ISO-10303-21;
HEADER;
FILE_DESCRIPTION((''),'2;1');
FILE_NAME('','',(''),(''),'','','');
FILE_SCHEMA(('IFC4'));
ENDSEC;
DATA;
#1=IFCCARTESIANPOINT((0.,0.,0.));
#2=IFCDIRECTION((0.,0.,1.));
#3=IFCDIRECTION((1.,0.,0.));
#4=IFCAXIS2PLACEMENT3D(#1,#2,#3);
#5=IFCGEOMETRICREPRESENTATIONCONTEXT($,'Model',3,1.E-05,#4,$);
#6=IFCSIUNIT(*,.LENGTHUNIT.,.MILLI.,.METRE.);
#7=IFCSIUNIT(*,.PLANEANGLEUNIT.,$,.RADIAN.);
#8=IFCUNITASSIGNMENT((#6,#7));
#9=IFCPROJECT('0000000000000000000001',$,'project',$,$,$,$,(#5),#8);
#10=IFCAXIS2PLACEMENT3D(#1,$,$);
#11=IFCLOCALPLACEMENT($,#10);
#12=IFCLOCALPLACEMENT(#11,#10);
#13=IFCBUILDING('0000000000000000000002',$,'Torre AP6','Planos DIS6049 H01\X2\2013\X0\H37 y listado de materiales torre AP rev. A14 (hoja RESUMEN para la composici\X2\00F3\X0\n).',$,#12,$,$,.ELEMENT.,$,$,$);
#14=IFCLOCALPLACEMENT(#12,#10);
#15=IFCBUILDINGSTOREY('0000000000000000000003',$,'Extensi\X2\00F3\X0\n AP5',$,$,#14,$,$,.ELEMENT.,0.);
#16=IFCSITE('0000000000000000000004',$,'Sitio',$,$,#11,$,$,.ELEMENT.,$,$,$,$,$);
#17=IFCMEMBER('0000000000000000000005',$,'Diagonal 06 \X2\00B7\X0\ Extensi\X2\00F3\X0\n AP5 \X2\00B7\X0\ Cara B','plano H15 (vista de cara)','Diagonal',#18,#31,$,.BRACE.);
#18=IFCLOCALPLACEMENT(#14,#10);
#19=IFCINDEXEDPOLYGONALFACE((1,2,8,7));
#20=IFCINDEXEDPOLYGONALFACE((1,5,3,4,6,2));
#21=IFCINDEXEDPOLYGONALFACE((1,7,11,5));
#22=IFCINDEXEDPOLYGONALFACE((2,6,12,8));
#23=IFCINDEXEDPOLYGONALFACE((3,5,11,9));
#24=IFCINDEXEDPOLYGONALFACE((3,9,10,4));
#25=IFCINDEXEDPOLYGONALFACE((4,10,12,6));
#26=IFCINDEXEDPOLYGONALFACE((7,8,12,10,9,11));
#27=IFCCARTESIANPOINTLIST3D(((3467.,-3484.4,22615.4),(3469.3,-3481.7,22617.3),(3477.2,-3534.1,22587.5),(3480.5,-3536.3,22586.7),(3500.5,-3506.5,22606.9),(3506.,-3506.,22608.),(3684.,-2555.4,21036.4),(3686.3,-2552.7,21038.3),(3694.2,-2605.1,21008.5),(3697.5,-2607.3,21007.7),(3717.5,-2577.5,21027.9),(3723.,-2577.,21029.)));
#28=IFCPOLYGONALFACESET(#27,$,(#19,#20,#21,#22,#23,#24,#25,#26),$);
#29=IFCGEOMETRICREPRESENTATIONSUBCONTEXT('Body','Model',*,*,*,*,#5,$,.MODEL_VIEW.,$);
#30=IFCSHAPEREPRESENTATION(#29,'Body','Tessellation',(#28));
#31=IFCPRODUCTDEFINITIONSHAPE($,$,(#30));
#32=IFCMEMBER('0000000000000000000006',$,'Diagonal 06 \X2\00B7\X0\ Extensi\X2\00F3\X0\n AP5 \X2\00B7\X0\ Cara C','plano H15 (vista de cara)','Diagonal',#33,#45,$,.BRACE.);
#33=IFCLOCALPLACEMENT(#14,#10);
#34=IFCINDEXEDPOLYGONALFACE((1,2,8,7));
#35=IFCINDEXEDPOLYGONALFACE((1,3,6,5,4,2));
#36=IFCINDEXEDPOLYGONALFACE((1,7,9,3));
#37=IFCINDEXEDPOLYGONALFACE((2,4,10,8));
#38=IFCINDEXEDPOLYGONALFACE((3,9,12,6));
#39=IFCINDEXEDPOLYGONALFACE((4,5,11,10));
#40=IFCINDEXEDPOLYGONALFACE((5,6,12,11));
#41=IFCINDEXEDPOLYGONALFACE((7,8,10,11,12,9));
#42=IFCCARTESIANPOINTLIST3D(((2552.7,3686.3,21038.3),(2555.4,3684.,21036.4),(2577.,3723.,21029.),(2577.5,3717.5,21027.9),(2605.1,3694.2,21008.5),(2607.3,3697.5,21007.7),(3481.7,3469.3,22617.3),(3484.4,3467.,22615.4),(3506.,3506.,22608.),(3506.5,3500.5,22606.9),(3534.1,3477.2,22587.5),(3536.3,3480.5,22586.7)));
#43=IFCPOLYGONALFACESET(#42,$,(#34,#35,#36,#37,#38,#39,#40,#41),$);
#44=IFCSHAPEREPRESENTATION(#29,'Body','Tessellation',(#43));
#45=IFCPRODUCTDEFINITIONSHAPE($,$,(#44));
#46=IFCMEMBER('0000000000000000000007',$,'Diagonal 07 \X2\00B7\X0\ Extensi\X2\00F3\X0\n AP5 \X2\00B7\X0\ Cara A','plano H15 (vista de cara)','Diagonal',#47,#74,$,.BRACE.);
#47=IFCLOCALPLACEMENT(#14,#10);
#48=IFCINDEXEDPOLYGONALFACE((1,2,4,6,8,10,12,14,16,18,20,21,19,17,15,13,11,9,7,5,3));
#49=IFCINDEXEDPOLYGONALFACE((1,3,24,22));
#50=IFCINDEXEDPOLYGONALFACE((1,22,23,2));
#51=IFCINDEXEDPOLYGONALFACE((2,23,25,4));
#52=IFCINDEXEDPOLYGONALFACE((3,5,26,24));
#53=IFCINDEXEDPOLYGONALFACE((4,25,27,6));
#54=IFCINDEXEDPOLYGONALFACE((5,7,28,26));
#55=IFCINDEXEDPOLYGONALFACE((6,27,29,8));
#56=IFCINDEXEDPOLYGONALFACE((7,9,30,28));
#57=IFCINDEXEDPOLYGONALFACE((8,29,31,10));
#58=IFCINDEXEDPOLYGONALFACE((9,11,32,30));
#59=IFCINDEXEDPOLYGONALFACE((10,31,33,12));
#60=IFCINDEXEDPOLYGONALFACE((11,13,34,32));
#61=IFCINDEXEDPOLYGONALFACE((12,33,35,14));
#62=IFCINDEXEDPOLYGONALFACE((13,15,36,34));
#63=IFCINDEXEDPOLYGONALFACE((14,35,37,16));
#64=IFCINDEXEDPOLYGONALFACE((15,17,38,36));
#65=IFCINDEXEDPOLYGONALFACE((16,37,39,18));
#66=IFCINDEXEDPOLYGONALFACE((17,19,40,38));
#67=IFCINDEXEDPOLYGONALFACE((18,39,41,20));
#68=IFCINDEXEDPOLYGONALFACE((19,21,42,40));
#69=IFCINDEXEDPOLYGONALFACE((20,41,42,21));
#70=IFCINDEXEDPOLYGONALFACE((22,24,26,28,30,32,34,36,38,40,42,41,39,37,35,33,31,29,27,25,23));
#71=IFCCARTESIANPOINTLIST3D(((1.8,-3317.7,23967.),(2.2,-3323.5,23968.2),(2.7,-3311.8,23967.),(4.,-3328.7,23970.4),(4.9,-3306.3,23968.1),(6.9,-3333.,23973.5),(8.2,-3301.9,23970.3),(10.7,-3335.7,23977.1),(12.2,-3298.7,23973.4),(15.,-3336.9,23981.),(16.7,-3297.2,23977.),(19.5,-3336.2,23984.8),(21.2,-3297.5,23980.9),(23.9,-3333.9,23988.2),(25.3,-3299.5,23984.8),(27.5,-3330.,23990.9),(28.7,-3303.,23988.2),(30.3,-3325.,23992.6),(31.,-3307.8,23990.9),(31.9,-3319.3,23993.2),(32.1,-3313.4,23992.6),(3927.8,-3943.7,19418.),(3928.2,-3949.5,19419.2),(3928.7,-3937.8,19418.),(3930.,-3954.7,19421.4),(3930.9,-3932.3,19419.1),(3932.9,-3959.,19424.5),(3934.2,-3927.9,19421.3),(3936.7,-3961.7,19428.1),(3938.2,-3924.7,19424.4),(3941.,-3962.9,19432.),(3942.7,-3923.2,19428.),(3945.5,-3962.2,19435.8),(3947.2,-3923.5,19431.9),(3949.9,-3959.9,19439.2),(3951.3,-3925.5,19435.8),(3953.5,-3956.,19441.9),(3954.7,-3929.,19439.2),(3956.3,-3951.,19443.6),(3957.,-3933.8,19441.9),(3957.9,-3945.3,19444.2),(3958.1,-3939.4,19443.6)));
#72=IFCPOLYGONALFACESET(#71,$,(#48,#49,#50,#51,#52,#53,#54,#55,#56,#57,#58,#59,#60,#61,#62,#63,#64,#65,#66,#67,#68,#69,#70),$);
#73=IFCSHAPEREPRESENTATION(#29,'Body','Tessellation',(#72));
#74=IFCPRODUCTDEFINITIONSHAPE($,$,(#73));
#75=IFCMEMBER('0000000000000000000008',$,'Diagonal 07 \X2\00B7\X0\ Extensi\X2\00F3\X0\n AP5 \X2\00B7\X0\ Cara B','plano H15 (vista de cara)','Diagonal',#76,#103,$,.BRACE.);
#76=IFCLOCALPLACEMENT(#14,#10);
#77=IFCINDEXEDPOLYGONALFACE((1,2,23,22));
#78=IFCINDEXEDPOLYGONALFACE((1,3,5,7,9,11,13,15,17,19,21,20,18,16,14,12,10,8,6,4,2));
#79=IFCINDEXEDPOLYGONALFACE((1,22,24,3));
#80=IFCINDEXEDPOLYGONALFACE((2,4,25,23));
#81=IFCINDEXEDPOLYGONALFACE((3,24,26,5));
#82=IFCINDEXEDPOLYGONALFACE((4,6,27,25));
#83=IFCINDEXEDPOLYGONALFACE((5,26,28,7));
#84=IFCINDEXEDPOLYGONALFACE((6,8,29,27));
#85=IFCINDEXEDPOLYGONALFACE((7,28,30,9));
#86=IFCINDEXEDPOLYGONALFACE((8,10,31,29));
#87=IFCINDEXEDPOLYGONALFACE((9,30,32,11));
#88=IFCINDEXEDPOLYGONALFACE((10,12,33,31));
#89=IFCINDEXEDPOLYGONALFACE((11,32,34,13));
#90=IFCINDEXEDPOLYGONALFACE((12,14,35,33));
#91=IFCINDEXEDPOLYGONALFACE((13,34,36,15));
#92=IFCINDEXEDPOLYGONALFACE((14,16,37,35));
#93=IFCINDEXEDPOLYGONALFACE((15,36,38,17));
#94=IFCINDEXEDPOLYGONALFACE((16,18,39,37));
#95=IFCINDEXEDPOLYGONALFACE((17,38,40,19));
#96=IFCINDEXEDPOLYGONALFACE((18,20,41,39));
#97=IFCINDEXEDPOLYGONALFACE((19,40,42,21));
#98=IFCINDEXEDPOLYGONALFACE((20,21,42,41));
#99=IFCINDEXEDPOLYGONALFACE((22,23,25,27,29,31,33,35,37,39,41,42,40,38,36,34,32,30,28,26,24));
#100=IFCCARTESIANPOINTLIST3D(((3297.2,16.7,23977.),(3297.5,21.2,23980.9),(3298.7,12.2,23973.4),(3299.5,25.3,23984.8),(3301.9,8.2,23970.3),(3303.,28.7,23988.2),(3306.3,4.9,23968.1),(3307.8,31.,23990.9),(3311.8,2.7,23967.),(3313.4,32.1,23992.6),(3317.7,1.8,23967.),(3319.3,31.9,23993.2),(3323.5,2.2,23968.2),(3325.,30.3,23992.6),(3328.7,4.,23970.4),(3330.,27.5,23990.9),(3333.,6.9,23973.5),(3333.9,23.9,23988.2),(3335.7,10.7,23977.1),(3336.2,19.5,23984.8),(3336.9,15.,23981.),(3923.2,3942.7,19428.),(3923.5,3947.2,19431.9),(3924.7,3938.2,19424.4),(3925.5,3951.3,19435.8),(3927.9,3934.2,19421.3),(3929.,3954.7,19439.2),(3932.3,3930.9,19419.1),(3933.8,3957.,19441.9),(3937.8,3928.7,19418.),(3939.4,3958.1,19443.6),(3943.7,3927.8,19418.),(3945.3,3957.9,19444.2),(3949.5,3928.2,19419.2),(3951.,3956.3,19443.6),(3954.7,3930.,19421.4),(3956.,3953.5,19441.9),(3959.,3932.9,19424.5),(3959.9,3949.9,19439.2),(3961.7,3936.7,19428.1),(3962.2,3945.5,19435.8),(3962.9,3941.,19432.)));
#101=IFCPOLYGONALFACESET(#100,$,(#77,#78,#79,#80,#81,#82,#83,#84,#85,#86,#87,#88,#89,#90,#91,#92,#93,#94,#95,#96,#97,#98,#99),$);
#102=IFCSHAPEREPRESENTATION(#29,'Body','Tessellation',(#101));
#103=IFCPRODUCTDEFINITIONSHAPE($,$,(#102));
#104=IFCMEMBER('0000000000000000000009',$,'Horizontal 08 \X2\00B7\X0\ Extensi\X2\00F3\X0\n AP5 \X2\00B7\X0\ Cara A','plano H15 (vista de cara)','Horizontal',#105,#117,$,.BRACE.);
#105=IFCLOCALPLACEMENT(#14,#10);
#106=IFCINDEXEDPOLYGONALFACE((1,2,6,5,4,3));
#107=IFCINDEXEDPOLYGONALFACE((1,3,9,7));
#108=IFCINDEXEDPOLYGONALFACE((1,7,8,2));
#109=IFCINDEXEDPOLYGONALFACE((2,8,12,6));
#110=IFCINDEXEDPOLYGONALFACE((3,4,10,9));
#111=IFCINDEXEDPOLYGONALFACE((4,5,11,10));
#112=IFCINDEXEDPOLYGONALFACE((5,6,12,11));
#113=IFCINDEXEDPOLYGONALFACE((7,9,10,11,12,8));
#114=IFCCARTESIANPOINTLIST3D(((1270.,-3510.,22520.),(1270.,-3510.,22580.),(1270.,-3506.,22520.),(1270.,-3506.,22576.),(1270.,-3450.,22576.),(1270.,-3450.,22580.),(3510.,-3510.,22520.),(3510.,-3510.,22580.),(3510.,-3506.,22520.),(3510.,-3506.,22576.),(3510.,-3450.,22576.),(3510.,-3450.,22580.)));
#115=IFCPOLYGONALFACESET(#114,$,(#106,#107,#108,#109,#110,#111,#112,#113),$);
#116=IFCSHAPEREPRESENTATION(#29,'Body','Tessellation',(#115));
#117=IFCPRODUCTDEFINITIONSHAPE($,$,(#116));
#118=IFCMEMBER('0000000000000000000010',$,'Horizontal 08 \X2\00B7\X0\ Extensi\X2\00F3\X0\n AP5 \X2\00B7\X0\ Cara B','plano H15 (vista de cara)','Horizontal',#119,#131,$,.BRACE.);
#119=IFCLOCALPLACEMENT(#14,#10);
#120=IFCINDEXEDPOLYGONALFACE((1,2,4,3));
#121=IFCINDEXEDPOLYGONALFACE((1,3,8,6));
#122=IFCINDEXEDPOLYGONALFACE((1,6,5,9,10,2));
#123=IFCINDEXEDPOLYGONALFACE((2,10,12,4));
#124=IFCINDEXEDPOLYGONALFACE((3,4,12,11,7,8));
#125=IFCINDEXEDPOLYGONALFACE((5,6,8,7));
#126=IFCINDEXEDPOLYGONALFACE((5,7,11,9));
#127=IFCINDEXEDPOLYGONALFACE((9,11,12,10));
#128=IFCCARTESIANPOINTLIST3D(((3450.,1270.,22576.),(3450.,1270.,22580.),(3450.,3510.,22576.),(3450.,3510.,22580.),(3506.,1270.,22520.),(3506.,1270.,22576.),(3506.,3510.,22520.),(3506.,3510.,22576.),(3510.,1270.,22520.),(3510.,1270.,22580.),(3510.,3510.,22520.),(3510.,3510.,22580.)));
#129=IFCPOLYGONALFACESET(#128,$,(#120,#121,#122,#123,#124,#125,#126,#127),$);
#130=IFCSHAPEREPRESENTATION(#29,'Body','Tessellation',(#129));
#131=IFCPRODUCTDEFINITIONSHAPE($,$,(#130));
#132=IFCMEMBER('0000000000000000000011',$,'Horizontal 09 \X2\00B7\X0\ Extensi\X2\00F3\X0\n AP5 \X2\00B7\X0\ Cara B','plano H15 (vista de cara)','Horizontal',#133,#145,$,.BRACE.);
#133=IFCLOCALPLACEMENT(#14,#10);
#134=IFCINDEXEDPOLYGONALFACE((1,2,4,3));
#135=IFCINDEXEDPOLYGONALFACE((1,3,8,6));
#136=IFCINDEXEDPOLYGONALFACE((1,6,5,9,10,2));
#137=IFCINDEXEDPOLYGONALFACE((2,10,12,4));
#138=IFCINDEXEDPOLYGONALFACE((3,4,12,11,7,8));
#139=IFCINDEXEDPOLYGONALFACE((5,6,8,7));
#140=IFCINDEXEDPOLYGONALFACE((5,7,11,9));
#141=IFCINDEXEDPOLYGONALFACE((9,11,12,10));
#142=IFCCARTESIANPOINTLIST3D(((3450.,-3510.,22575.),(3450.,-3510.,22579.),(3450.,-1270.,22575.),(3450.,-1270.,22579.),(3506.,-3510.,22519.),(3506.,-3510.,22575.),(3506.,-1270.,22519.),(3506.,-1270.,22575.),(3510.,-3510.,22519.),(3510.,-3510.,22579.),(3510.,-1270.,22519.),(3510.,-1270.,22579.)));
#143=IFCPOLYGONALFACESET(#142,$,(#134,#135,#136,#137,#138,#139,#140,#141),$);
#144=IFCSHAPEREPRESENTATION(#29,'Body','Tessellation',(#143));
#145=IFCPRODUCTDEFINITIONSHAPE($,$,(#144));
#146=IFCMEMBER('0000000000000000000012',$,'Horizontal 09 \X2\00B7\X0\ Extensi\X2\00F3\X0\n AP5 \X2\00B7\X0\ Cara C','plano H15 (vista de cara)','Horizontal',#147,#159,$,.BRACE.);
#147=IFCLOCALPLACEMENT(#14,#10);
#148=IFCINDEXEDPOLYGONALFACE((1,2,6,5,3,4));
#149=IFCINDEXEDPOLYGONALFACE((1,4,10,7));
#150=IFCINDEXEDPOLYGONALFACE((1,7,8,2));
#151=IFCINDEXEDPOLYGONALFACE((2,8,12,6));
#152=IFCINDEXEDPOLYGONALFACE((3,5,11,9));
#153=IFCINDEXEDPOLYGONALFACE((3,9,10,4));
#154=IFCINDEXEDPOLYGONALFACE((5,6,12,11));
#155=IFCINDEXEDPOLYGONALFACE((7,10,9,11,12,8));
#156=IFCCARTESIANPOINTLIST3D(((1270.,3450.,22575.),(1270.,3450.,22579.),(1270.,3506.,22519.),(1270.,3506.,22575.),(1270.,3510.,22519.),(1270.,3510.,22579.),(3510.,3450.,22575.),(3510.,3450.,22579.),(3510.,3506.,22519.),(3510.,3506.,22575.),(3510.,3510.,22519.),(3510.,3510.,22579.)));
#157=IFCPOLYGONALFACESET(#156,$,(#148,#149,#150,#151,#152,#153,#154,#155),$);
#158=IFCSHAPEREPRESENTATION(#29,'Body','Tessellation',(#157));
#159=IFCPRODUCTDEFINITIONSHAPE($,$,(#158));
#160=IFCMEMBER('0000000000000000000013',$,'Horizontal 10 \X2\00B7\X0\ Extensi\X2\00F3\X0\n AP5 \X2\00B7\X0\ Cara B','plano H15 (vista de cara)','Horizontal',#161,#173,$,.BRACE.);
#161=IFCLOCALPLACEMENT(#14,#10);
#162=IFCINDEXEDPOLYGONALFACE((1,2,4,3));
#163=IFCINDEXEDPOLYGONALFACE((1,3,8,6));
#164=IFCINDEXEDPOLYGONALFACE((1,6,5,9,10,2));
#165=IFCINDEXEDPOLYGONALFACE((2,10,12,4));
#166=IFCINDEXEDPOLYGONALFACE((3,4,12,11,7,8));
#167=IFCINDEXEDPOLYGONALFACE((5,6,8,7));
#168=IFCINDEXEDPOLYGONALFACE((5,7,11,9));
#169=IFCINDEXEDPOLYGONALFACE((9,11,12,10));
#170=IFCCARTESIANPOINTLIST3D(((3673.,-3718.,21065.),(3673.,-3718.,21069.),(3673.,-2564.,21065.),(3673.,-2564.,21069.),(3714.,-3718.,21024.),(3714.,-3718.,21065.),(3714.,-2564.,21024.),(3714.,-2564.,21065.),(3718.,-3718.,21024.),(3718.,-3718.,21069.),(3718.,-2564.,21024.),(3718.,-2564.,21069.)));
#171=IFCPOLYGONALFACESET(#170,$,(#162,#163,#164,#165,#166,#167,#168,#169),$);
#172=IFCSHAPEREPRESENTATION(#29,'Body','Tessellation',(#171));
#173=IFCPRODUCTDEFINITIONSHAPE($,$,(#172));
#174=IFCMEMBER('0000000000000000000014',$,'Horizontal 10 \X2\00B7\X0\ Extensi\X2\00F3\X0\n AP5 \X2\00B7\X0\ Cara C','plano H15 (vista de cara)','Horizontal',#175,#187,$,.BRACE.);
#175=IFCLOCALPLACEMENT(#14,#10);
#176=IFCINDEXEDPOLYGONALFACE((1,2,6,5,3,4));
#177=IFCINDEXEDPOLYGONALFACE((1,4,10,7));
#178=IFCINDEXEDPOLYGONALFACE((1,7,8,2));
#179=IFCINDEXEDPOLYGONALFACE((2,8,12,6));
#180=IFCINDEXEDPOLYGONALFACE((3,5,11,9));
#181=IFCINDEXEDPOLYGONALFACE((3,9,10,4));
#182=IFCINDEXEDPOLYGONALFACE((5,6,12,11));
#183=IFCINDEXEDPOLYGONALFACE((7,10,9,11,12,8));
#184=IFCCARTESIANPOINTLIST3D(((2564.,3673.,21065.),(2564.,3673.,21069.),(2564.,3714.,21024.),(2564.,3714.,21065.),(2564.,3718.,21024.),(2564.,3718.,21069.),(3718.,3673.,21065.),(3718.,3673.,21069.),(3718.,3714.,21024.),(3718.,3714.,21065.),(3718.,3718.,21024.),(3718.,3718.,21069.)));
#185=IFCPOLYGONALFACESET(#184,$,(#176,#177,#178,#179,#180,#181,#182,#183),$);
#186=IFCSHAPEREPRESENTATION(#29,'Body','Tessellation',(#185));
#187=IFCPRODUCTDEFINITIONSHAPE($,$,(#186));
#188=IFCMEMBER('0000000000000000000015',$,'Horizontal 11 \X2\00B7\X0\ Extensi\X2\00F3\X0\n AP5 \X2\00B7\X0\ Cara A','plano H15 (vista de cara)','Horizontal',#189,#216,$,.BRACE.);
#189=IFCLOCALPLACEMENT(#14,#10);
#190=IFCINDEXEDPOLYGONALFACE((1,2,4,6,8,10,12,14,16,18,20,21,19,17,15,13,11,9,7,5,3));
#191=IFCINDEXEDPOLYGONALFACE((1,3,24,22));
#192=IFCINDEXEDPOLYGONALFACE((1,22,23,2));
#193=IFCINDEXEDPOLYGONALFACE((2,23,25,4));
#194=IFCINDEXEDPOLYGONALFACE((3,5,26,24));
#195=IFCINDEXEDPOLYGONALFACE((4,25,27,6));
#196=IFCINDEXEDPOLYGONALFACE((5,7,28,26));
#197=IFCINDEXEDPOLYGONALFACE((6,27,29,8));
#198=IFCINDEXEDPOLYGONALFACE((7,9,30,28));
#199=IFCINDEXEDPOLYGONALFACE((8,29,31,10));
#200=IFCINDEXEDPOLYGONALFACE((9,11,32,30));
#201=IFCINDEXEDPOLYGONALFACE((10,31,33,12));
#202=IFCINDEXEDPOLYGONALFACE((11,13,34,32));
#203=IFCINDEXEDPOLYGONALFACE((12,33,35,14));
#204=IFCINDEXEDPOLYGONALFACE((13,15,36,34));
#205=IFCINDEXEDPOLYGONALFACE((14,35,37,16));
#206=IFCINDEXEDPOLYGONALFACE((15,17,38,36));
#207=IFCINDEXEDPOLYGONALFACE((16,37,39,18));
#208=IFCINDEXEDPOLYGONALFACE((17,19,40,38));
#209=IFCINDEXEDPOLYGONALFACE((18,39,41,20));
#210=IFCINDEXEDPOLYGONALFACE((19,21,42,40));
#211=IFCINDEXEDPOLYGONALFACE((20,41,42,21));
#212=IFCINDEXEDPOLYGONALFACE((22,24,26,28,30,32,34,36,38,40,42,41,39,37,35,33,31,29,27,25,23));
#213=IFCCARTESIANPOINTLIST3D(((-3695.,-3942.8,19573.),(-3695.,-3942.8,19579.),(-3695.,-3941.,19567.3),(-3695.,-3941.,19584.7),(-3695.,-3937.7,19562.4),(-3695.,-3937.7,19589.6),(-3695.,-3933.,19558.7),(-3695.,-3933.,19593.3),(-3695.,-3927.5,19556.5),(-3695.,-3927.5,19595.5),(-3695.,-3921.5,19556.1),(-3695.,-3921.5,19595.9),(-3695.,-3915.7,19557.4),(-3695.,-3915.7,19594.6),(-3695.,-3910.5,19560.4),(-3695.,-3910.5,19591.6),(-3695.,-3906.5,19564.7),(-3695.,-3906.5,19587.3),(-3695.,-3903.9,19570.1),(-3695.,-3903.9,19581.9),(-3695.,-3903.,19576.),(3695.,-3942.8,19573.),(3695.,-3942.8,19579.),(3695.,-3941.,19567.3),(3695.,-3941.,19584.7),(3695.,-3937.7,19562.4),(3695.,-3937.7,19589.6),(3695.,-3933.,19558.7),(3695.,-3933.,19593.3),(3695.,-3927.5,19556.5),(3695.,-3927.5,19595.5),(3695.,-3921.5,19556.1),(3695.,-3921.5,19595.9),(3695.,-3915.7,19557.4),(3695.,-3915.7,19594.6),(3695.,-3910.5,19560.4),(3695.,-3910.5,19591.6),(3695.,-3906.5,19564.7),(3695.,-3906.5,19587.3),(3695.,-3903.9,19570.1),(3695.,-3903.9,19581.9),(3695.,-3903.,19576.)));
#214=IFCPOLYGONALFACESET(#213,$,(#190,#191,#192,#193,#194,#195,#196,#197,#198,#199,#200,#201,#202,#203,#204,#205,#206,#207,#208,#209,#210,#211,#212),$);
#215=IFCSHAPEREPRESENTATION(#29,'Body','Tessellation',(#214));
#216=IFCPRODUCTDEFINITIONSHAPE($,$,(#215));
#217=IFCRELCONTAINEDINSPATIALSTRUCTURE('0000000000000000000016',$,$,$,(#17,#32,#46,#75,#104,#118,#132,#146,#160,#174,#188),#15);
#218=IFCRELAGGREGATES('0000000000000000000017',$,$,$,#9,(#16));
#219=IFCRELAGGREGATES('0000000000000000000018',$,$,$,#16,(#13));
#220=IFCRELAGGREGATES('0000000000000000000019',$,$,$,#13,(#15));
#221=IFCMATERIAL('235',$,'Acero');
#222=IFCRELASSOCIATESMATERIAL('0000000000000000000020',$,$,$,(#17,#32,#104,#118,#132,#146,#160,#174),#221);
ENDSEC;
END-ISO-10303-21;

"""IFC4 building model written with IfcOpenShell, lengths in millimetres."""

from ifc_helpers import new_model, si_unit, frame, frame_2d, origin, origin_with_axes, place, context, subcontext, project, spatial, circle, l_section, extrude, material, element, save


model = new_model("IFC4")

# Units and contexts
model_context = context("Model", 3, precision=1e-05, world=origin_with_axes())
body_context = subcontext(model_context, "Body", "Model", "MODEL_VIEW")
ifc_project = project(units=[si_unit("LENGTHUNIT", "METRE", prefix="MILLI"), si_unit("PLANEANGLEUNIT", "RADIAN")], contexts=[model_context])

# Site, building, storey
site_placement = place(None, origin())
site = spatial("IfcSite", under=ifc_project, at=site_placement, Name="Sitio", CompositionType="ELEMENT")
building_placement = place(site_placement, origin())
building = spatial("IfcBuilding", under=site, at=building_placement, Name="Torre AP6", Description="Planos DIS6049 H01–H37 y listado de materiales torre AP rev. A14 (hoja RESUMEN para la composición).", CompositionType="ELEMENT")
storey_placement = place(building_placement, origin())
storey = spatial("IfcBuildingStorey", under=building, at=storey_placement, Name="Extensión AP5", CompositionType="ELEMENT", Elevation=0.0)

# Members
ifc_material_1 = material(Name="235", Category="Acero")
for number, where, z_axis, x_axis, name in (
    (1, (3723.0, -2577.0, 21029.0), (-0.117626, -0.503571, 0.855909), (-0.815383, 0.540952, 0.20621), "Diagonal 06 · Extensión AP5 · Cara B"),
    (2, (2577.0, 3723.0, 21029.0), (0.503571, -0.117626, 0.855909), (-0.540952, -0.815383, 0.20621), "Diagonal 06 · Extensión AP5 · Cara C"),
):
    element("IfcMember", number, at=place(storey_placement, frame(where, z_axis=z_axis, x_axis=x_axis)), inside=storey, material=ifc_material_1, Name=name, Description="plano H15 (vista de cara)", ObjectType="Diagonal", PredefinedType="BRACE", context=body_context, shape_type="SweptSolid", body=[
        extrude(l_section(Depth=45.0, Width=45.0, Thickness=4.0, at=frame_2d((22.5, 22.5))), None, (0.0, 0.0, 1.0), 1844.8),
    ])
for number, where, z_axis, x_axis, name in (
    (3, (3943.0, -3943.0, 19431.0), (-0.649847, 0.103618, 0.752969), (-0.237576, 0.913334, -0.330725), "Diagonal 07 · Extensión AP5 · Cara A"),
    (4, (3943.0, 3943.0, 19431.0), (-0.103618, -0.649847, 0.752969), (-0.913334, -0.237576, -0.330725), "Diagonal 07 · Extensión AP5 · Cara B"),
):
    element("IfcMember", number, at=place(storey_placement, frame(where, z_axis=z_axis, x_axis=x_axis)), inside=storey, Name=name, Description="plano H15 (vista de cara)", ObjectType="Diagonal", PredefinedType="BRACE", context=body_context, shape_type="SweptSolid", body=[
        extrude(circle(Radius=20.0), None, (0.0, 0.0, 1.0), 6041.4),
    ])
for number, where, z_axis, x_axis, name in (
    (5, (3510.0, -3510.0, 22580.0), (-1.0, 0.0, 0.0), (0.0, 1.0, 0.0), "Horizontal 08 · Extensión AP5 · Cara A"),
    (6, (3510.0, 3510.0, 22580.0), (0.0, -1.0, 0.0), (-1.0, 0.0, 0.0), "Horizontal 08 · Extensión AP5 · Cara B"),
    (7, (3510.0, -1270.0, 22579.0), (0.0, -1.0, 0.0), (-1.0, 0.0, 0.0), "Horizontal 09 · Extensión AP5 · Cara B"),
    (8, (1270.0, 3510.0, 22579.0), (1.0, 0.0, 0.0), (0.0, -1.0, 0.0), "Horizontal 09 · Extensión AP5 · Cara C"),
):
    element("IfcMember", number, at=place(storey_placement, frame(where, z_axis=z_axis, x_axis=x_axis)), inside=storey, material=ifc_material_1, Name=name, Description="plano H15 (vista de cara)", ObjectType="Horizontal", PredefinedType="BRACE", context=body_context, shape_type="SweptSolid", body=[
        extrude(l_section(Depth=60.0, Width=60.0, Thickness=4.0, at=frame_2d((30.0, 30.0))), None, (0.0, 0.0, 1.0), 2240.0),
    ])
for number, where, z_axis, x_axis, name in (
    (9, (3718.0, -2564.0, 21069.0), (0.0, -1.0, 0.0), (-1.0, 0.0, 0.0), "Horizontal 10 · Extensión AP5 · Cara B"),
    (10, (2564.0, 3718.0, 21069.0), (1.0, 0.0, 0.0), (0.0, -1.0, 0.0), "Horizontal 10 · Extensión AP5 · Cara C"),
):
    element("IfcMember", number, at=place(storey_placement, frame(where, z_axis=z_axis, x_axis=x_axis)), inside=storey, material=ifc_material_1, Name=name, Description="plano H15 (vista de cara)", ObjectType="Horizontal", PredefinedType="BRACE", context=body_context, shape_type="SweptSolid", body=[
        extrude(l_section(Depth=45.0, Width=45.0, Thickness=4.0, at=frame_2d((22.5, 22.5))), None, (0.0, 0.0, 1.0), 1154.0),
    ])
for number, where, z_axis, x_axis, name in (
    (11, (3695.0, -3923.0, 19576.0), (-1.0, 0.0, 0.0), (0.0, 1.0, 0.0), "Horizontal 11 · Extensión AP5 · Cara A"),
):
    element("IfcMember", number, at=place(storey_placement, frame(where, z_axis=z_axis, x_axis=x_axis)), inside=storey, Name=name, Description="plano H15 (vista de cara)", ObjectType="Horizontal", PredefinedType="BRACE", context=body_context, shape_type="SweptSolid", body=[
        extrude(circle(Radius=20.0), None, (0.0, 0.0, 1.0), 7390.0),
    ])

save(model, "model.ifc")
